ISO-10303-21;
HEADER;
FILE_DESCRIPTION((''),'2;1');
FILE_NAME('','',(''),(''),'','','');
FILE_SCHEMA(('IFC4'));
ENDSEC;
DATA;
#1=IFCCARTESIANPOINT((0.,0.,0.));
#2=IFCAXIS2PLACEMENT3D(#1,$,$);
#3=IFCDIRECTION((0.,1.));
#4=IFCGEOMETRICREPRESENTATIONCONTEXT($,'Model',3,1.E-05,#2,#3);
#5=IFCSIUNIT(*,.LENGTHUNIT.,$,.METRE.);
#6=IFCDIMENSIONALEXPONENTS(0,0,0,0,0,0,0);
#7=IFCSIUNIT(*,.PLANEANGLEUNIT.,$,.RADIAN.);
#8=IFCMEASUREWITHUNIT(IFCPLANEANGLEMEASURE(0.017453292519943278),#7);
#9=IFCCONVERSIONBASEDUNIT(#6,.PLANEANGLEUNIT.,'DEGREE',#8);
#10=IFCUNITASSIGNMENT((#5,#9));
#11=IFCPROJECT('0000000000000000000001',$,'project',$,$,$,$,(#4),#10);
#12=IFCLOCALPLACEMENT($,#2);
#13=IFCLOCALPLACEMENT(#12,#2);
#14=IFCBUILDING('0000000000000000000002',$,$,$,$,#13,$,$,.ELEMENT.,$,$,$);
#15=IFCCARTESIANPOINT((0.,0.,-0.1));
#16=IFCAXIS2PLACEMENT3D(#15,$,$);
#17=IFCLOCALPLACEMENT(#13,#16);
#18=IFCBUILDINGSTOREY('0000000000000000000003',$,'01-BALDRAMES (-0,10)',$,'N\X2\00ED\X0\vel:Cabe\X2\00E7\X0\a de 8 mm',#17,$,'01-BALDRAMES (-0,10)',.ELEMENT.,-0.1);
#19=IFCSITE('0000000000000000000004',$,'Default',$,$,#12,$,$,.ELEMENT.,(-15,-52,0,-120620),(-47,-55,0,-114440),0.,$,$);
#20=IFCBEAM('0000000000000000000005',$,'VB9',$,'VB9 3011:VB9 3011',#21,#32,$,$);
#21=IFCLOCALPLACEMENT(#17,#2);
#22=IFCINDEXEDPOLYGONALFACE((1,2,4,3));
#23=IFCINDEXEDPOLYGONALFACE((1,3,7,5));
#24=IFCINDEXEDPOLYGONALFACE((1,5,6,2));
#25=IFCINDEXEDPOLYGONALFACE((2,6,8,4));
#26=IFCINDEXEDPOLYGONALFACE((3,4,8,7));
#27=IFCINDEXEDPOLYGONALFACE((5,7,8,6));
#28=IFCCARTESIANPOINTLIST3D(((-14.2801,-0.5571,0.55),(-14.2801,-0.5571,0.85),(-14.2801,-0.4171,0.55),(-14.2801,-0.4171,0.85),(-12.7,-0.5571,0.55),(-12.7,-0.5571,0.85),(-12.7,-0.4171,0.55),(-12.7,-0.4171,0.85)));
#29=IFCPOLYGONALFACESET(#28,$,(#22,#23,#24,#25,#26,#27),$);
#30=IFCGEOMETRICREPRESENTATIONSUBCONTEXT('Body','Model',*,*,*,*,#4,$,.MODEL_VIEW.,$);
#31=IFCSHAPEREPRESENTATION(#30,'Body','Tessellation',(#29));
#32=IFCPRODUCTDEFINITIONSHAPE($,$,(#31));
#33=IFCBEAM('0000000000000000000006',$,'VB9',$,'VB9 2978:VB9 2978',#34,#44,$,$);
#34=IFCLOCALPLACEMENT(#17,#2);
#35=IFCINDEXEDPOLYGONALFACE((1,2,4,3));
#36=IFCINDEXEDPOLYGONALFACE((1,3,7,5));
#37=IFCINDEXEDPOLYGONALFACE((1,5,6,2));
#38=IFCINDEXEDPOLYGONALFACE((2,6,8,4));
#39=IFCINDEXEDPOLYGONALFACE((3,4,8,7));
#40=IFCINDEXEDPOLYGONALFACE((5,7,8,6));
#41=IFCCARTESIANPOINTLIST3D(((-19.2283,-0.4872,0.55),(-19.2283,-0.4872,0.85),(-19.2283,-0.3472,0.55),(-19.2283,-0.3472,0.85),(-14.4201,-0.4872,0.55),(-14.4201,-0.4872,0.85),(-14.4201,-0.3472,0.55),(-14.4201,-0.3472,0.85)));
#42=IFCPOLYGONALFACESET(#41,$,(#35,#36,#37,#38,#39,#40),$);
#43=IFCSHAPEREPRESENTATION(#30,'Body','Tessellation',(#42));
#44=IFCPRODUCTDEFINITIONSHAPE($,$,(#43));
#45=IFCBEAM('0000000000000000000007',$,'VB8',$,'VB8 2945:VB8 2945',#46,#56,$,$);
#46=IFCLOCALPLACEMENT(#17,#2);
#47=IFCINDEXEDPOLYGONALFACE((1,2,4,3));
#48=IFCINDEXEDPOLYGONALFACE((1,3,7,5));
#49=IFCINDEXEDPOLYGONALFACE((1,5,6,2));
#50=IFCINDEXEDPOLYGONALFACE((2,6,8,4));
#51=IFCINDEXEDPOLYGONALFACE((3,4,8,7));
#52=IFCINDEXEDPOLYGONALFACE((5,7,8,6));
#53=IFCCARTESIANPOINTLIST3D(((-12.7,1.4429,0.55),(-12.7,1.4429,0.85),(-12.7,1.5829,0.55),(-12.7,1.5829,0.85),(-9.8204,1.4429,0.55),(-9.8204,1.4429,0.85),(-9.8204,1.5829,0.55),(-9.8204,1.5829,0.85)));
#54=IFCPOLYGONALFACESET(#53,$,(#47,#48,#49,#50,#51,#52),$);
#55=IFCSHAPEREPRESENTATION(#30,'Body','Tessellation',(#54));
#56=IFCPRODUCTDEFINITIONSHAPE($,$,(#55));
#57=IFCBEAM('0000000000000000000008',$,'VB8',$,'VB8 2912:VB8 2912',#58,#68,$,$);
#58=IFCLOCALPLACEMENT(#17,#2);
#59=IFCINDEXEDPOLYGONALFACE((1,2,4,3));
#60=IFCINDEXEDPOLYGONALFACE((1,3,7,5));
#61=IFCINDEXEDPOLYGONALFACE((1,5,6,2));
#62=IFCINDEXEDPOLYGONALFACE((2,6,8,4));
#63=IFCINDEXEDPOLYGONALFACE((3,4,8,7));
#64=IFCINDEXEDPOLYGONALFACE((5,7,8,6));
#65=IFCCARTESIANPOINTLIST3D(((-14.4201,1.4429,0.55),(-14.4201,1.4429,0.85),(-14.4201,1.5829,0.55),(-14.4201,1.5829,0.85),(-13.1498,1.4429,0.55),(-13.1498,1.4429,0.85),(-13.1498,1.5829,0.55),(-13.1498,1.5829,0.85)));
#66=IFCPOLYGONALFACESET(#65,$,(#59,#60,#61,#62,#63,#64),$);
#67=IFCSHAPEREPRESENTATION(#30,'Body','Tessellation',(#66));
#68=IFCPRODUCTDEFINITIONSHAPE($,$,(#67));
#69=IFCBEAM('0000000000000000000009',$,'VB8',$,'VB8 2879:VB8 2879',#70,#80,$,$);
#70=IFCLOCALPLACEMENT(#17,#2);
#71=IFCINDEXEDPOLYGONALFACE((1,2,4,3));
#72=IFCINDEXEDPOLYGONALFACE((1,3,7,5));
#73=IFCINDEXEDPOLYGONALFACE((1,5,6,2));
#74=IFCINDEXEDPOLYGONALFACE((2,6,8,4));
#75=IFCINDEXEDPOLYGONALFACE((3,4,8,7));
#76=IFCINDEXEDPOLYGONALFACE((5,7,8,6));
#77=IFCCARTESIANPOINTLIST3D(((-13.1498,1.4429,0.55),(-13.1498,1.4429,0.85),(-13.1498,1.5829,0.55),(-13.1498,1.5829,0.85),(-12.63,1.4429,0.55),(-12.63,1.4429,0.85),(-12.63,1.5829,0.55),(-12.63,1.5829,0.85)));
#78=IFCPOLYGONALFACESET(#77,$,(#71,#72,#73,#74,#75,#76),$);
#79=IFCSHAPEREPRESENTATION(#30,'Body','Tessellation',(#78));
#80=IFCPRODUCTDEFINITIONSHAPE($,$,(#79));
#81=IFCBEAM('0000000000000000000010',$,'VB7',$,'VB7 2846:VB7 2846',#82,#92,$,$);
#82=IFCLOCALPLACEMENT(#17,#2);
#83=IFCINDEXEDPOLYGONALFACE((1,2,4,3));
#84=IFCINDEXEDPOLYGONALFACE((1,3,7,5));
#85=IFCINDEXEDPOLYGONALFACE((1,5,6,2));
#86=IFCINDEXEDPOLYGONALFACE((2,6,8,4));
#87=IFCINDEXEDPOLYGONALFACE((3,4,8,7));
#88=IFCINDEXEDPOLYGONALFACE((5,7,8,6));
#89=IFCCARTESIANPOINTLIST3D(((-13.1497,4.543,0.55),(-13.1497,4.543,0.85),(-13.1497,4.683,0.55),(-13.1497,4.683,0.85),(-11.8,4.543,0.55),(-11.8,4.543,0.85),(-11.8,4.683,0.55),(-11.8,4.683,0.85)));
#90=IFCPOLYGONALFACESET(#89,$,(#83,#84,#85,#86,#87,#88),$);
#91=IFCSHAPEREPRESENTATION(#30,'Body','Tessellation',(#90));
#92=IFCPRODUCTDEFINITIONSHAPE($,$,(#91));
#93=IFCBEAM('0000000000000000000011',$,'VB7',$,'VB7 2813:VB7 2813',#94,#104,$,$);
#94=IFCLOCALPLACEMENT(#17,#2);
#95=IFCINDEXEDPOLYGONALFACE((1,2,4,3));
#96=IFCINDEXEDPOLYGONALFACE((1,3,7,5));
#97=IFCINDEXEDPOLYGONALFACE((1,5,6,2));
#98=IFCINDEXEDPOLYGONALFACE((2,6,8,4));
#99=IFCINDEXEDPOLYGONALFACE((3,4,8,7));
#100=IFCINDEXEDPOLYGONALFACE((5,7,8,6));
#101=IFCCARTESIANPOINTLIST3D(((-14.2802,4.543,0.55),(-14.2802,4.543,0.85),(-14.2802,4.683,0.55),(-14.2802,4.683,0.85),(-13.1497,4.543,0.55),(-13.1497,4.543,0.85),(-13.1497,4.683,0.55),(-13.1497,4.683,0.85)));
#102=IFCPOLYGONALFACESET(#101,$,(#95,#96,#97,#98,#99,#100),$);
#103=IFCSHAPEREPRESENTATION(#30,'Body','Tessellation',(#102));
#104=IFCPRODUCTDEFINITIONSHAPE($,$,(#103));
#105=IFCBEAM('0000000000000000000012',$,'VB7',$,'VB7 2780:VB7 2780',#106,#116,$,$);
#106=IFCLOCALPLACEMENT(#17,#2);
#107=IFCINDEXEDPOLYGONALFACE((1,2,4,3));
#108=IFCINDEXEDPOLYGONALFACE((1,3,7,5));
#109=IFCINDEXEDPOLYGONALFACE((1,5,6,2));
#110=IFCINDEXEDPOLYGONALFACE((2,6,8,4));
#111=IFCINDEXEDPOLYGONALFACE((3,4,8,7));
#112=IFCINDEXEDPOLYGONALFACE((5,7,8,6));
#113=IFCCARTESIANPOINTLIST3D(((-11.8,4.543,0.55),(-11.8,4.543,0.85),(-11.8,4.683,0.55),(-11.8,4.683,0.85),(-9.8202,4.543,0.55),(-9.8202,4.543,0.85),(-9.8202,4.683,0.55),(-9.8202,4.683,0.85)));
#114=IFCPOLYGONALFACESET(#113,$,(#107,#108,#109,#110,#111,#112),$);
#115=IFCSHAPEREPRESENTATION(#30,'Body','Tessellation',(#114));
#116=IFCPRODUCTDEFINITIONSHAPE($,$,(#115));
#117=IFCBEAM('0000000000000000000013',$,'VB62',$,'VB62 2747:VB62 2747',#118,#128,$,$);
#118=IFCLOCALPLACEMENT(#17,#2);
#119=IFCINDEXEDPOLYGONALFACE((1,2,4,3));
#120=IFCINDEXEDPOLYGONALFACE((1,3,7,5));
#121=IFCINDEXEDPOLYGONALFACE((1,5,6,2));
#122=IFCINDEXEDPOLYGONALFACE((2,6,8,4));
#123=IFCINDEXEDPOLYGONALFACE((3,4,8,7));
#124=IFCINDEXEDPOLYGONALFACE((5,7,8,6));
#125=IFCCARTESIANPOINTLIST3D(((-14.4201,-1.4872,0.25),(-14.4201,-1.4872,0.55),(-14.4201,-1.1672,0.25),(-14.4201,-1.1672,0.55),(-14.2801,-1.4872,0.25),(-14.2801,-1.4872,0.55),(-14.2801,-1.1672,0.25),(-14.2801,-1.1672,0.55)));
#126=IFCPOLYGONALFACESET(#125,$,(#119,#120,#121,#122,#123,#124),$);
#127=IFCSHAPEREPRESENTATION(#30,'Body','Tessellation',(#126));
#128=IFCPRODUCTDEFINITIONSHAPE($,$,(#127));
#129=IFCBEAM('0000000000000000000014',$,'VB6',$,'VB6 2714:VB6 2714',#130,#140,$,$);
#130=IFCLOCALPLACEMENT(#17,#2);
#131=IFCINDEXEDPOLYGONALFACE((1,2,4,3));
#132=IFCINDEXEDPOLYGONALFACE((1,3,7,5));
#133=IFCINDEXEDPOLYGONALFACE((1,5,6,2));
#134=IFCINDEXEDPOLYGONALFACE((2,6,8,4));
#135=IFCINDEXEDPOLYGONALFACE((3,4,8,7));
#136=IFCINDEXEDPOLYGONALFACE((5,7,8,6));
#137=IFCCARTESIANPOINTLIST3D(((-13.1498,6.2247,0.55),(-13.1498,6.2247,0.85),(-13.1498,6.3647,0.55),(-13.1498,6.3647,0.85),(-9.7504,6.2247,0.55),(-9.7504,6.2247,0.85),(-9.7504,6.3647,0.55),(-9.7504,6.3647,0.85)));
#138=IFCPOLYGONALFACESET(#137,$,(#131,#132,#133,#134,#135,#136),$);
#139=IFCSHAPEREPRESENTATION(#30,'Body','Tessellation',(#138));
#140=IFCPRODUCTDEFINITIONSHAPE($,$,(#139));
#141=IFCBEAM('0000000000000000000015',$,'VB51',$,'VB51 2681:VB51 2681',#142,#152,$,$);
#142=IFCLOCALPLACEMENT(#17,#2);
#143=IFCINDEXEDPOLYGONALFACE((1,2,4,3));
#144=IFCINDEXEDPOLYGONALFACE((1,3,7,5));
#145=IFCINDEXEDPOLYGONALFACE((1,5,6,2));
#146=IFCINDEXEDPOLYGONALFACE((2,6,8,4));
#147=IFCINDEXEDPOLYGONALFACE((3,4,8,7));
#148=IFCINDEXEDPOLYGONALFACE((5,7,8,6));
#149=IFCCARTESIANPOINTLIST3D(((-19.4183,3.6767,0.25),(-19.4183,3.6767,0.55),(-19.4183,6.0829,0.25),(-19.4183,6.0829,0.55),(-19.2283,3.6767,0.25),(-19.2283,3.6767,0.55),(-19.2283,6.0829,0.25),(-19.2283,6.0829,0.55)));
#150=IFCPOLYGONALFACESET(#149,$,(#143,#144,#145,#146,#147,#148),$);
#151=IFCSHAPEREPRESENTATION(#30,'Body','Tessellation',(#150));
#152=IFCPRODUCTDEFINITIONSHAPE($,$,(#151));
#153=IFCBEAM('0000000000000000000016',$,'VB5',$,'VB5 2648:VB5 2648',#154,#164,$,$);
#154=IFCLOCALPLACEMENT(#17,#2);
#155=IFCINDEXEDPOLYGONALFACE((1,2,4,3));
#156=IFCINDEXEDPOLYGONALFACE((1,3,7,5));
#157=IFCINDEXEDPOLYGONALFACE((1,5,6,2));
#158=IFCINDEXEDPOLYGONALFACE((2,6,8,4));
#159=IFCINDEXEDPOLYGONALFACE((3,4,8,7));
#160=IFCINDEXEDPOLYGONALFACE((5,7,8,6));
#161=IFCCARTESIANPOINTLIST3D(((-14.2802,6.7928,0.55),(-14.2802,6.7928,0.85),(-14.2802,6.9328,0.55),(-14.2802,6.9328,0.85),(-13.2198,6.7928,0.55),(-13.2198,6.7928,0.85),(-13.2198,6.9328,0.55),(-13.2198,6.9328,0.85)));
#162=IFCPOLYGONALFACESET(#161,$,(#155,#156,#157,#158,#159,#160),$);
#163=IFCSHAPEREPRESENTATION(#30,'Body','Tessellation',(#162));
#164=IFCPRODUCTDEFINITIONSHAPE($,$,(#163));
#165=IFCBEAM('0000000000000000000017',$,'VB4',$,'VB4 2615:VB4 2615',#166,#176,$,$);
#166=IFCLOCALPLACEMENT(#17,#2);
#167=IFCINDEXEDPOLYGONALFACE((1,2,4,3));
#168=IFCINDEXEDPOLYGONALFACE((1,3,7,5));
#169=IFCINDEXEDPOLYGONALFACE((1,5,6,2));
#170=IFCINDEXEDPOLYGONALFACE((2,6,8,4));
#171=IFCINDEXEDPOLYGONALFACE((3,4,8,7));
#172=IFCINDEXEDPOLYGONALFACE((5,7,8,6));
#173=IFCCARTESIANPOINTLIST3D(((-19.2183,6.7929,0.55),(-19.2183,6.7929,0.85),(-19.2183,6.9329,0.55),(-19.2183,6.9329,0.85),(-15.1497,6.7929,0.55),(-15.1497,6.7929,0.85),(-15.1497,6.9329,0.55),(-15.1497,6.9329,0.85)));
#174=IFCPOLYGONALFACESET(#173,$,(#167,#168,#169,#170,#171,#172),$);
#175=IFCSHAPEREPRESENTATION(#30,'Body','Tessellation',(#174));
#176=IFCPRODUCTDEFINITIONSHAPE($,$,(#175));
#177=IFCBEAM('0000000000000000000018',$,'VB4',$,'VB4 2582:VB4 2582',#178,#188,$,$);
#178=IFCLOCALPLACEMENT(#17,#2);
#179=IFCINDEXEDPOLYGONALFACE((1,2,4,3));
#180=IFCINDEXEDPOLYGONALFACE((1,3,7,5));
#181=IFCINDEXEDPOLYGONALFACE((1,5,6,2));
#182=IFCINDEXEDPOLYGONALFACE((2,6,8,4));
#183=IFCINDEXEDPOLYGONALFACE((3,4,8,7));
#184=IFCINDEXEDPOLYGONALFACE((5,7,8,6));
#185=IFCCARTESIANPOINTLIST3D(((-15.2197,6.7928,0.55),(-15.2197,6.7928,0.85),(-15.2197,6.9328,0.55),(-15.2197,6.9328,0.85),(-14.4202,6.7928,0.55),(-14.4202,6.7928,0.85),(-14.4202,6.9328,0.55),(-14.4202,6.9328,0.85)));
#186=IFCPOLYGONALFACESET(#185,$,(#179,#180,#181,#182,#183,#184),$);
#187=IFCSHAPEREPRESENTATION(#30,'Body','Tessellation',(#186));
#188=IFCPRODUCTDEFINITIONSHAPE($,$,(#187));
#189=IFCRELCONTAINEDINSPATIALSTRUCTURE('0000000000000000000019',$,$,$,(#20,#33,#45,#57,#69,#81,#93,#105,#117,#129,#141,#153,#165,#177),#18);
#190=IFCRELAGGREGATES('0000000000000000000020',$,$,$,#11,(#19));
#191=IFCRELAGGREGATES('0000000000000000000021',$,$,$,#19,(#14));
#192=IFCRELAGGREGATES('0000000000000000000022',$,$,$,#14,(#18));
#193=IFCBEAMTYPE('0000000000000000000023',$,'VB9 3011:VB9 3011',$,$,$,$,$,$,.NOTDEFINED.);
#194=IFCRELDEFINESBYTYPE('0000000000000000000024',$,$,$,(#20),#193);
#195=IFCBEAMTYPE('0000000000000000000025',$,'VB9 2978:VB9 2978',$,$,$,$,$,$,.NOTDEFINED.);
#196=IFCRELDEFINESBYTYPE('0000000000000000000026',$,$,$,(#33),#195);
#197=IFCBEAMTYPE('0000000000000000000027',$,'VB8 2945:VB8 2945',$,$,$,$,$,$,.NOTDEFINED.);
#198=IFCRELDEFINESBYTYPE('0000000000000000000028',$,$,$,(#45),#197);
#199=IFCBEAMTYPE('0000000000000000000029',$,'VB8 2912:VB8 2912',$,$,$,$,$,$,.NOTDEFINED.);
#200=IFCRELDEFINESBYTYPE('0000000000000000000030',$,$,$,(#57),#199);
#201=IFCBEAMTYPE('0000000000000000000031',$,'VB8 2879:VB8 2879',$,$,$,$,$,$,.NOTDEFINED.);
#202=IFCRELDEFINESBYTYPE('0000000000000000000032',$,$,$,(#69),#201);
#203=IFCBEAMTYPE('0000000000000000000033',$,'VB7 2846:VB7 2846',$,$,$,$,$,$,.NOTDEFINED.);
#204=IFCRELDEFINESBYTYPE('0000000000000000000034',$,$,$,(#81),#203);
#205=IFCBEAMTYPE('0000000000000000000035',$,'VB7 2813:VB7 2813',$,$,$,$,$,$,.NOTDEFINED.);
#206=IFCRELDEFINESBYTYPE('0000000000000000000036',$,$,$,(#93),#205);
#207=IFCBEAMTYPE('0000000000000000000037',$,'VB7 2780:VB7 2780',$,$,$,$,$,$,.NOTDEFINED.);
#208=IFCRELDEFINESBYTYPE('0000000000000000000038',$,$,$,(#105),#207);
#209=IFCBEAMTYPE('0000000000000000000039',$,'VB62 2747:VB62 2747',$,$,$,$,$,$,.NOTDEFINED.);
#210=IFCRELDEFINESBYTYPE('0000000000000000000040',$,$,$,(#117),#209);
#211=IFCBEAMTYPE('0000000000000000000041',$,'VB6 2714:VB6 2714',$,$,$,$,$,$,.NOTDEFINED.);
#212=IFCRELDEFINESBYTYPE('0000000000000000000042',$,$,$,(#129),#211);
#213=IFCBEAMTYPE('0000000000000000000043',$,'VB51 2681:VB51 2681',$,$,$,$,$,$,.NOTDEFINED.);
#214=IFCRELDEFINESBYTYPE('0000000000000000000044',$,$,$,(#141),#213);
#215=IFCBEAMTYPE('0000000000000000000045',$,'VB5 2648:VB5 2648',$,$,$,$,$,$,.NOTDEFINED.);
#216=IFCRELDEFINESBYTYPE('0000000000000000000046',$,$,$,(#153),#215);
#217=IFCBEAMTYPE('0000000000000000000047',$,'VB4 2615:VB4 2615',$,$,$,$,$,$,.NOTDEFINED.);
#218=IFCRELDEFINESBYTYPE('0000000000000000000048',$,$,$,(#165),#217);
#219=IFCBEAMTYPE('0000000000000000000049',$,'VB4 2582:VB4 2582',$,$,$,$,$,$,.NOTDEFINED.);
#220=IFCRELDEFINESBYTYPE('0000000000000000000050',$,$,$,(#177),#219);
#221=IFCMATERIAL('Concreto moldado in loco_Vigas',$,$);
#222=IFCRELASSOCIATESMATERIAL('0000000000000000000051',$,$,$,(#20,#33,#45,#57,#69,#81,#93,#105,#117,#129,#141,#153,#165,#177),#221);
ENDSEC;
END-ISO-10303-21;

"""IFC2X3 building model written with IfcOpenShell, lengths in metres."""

from ifc_helpers import new_model, entity, si_unit, converted_unit, direction, frame, frame_2d, origin, origin_2d_with_axis, place, context, subcontext, project, spatial, rectangle, extrude, material, type_object, element, save


model = new_model("IFC2X3")

# Units and contexts
model_context = context("Model", 3, precision=1e-05, world=origin(), true_north=direction((0.0, 1.0)))
body_context = subcontext(model_context, "Body", "Model", "MODEL_VIEW")
ifc_project = project(units=[si_unit("LENGTHUNIT", "METRE"), converted_unit("PLANEANGLEUNIT", "DEGREE", entity("IfcPlaneAngleMeasure", 0.017453292519943278), si_unit("PLANEANGLEUNIT", "RADIAN"), dimensions=[0, 0, 0, 0, 0, 0, 0])], contexts=[model_context])

# Site, building, storey
site_placement = place(None, origin())
site = spatial("IfcSite", under=ifc_project, at=site_placement, Name="Default", CompositionType="ELEMENT", RefLatitude=(-15, -52, 0, -120620), RefLongitude=(-47, -55, 0, -114440), RefElevation=0.0)
building_placement = place(site_placement, origin())
building = spatial("IfcBuilding", under=site, at=building_placement, CompositionType="ELEMENT")
storey_placement = place(building_placement, frame((0.0, 0.0, -0.1)))
storey = spatial("IfcBuildingStorey", under=building, at=storey_placement, Name="01-BALDRAMES (-0,10)", ObjectType="Nível:Cabeça de 8 mm", LongName="01-BALDRAMES (-0,10)", CompositionType="ELEMENT", Elevation=-0.1)

# Beams
ifc_material_1 = material(Name="Concreto moldado in loco_Vigas")
beam_type_1 = type_object("IfcBeamType", Name="VB9 3011:VB9 3011", PredefinedType="NOTDEFINED")
beam_1_placement = place(storey_placement, origin())
element("IfcBeam", 1, at=beam_1_placement, inside=storey, type_object=beam_type_1, material=ifc_material_1, Name="VB9", ObjectType="VB9 3011:VB9 3011", context=body_context, shape_type="SweptSolid", body=[
    extrude(rectangle(XDim=0.3, YDim=0.14, at=origin_2d_with_axis()), frame((-14.2801, -0.4871, 0.7), z_axis=(1.0, 0.0, 0.0), x_axis=(0.0, 0.0, -1.0)), (0.0, 0.0, 1.0), 1.5801),
])
beam_type_2 = type_object("IfcBeamType", Name="VB9 2978:VB9 2978", PredefinedType="NOTDEFINED")
beam_2_placement = place(storey_placement, origin())
element("IfcBeam", 2, at=beam_2_placement, inside=storey, type_object=beam_type_2, material=ifc_material_1, Name="VB9", ObjectType="VB9 2978:VB9 2978", context=body_context, shape_type="SweptSolid", body=[
    extrude(rectangle(XDim=0.3, YDim=0.14, at=origin_2d_with_axis()), frame((-19.2283, -0.4172, 0.7), z_axis=(1.0, 0.0, 0.0), x_axis=(0.0, 0.0, -1.0)), (0.0, 0.0, 1.0), 4.8082),
])
beam_type_3 = type_object("IfcBeamType", Name="VB8 2945:VB8 2945", PredefinedType="NOTDEFINED")
beam_3_placement = place(storey_placement, origin())
element("IfcBeam", 3, at=beam_3_placement, inside=storey, type_object=beam_type_3, material=ifc_material_1, Name="VB8", ObjectType="VB8 2945:VB8 2945", context=body_context, shape_type="SweptSolid", body=[
    extrude(rectangle(XDim=0.3, YDim=0.14, at=origin_2d_with_axis()), frame((-12.7, 1.5129, 0.7), z_axis=(1.0, 0.0, 0.0), x_axis=(0.0, 0.0, -1.0)), (0.0, 0.0, 1.0), 2.8796),
])
beam_type_4 = type_object("IfcBeamType", Name="VB8 2912:VB8 2912", PredefinedType="NOTDEFINED")
beam_4_placement = place(storey_placement, origin())
element("IfcBeam", 4, at=beam_4_placement, inside=storey, type_object=beam_type_4, material=ifc_material_1, Name="VB8", ObjectType="VB8 2912:VB8 2912", context=body_context, shape_type="SweptSolid", body=[
    extrude(rectangle(XDim=0.3, YDim=0.14, at=origin_2d_with_axis()), frame((-14.4201, 1.5129, 0.7), z_axis=(1.0, 0.0, 0.0), x_axis=(0.0, 0.0, -1.0)), (0.0, 0.0, 1.0), 1.2703),
])
beam_type_5 = type_object("IfcBeamType", Name="VB8 2879:VB8 2879", PredefinedType="NOTDEFINED")
beam_5_placement = place(storey_placement, origin())
element("IfcBeam", 5, at=beam_5_placement, inside=storey, type_object=beam_type_5, material=ifc_material_1, Name="VB8", ObjectType="VB8 2879:VB8 2879", context=body_context, shape_type="SweptSolid", body=[
    extrude(rectangle(XDim=0.3, YDim=0.14, at=origin_2d_with_axis()), frame((-13.1498, 1.5129, 0.7), z_axis=(1.0, 0.0, 0.0), x_axis=(0.0, 0.0, -1.0)), (0.0, 0.0, 1.0), 0.5198),
])
beam_type_6 = type_object("IfcBeamType", Name="VB7 2846:VB7 2846", PredefinedType="NOTDEFINED")
beam_6_placement = place(storey_placement, origin())
element("IfcBeam", 6, at=beam_6_placement, inside=storey, type_object=beam_type_6, material=ifc_material_1, Name="VB7", ObjectType="VB7 2846:VB7 2846", context=body_context, shape_type="SweptSolid", body=[
    extrude(rectangle(XDim=0.3, YDim=0.14, at=frame_2d((0.0, 0.0), x_axis=(1.0, 0.0))), frame((-13.1497, 4.613, 0.7), z_axis=(1.0, 0.0, 0.0), x_axis=(0.0, 0.0, -1.0)), (0.0, 0.0, 1.0), 1.3497),
])
beam_type_7 = type_object("IfcBeamType", Name="VB7 2813:VB7 2813", PredefinedType="NOTDEFINED")
beam_7_placement = place(storey_placement, origin())
element("IfcBeam", 7, at=beam_7_placement, inside=storey, type_object=beam_type_7, material=ifc_material_1, Name="VB7", ObjectType="VB7 2813:VB7 2813", context=body_context, shape_type="SweptSolid", body=[
    extrude(rectangle(XDim=0.3, YDim=0.14, at=frame_2d((0.0, 0.0), x_axis=(1.0, 0.0))), frame((-14.2802, 4.613, 0.7), z_axis=(1.0, 0.0, 0.0), x_axis=(0.0, 0.0, -1.0)), (0.0, 0.0, 1.0), 1.1305),
])
beam_type_8 = type_object("IfcBeamType", Name="VB7 2780:VB7 2780", PredefinedType="NOTDEFINED")
beam_8_placement = place(storey_placement, origin())
element("IfcBeam", 8, at=beam_8_placement, inside=storey, type_object=beam_type_8, material=ifc_material_1, Name="VB7", ObjectType="VB7 2780:VB7 2780", context=body_context, shape_type="SweptSolid", body=[
    extrude(rectangle(XDim=0.3, YDim=0.14, at=frame_2d((0.0, 0.0), x_axis=(1.0, 0.0))), frame((-11.8, 4.613, 0.7), z_axis=(1.0, 0.0, 0.0), x_axis=(0.0, 0.0, -1.0)), (0.0, 0.0, 1.0), 1.9798),
])
beam_type_9 = type_object("IfcBeamType", Name="VB62 2747:VB62 2747", PredefinedType="NOTDEFINED")
beam_9_placement = place(storey_placement, origin())
element("IfcBeam", 9, at=beam_9_placement, inside=storey, type_object=beam_type_9, material=ifc_material_1, Name="VB62", ObjectType="VB62 2747:VB62 2747", context=body_context, shape_type="SweptSolid", body=[
    extrude(rectangle(XDim=0.3, YDim=0.32, at=frame_2d((0.0, 0.0), x_axis=(0.0, 1.0))), frame((-14.4201, -1.3272, 0.4), z_axis=(1.0, 0.0, 0.0), x_axis=(0.0, -1.0, 0.0)), (0.0, 0.0, 1.0), 0.14),
])
beam_type_10 = type_object("IfcBeamType", Name="VB6 2714:VB6 2714", PredefinedType="NOTDEFINED")
beam_10_placement = place(storey_placement, origin())
element("IfcBeam", 10, at=beam_10_placement, inside=storey, type_object=beam_type_10, material=ifc_material_1, Name="VB6", ObjectType="VB6 2714:VB6 2714", context=body_context, shape_type="SweptSolid", body=[
    extrude(rectangle(XDim=0.3, YDim=0.14, at=frame_2d((0.0, 0.0), x_axis=(1.0, 0.0))), frame((-13.1498, 6.2947, 0.7), z_axis=(1.0, 0.0, 0.0), x_axis=(0.0, 0.0, -1.0)), (0.0, 0.0, 1.0), 3.3994),
])
beam_type_11 = type_object("IfcBeamType", Name="VB51 2681:VB51 2681", PredefinedType="NOTDEFINED")
beam_11_placement = place(storey_placement, origin())
element("IfcBeam", 11, at=beam_11_placement, inside=storey, type_object=beam_type_11, material=ifc_material_1, Name="VB51", ObjectType="VB51 2681:VB51 2681", context=body_context, shape_type="SweptSolid", body=[
    extrude(rectangle(XDim=0.3, YDim=2.4062, at=frame_2d((0.0, 0.0), x_axis=(0.0, 1.0))), frame((-19.4183, 4.8798, 0.4), z_axis=(1.0, 0.0, 0.0), x_axis=(0.0, -1.0, 0.0)), (0.0, 0.0, 1.0), 0.19),
])
beam_type_12 = type_object("IfcBeamType", Name="VB5 2648:VB5 2648", PredefinedType="NOTDEFINED")
beam_12_placement = place(storey_placement, origin())
element("IfcBeam", 12, at=beam_12_placement, inside=storey, type_object=beam_type_12, material=ifc_material_1, Name="VB5", ObjectType="VB5 2648:VB5 2648", context=body_context, shape_type="SweptSolid", body=[
    extrude(rectangle(XDim=0.3, YDim=0.14, at=frame_2d((0.0, 0.0), x_axis=(1.0, 0.0))), frame((-14.2802, 6.8628, 0.7), z_axis=(1.0, 0.0, 0.0), x_axis=(0.0, 0.0, -1.0)), (0.0, 0.0, 1.0), 1.0604),
])
beam_type_13 = type_object("IfcBeamType", Name="VB4 2615:VB4 2615", PredefinedType="NOTDEFINED")
beam_13_placement = place(storey_placement, origin())
element("IfcBeam", 13, at=beam_13_placement, inside=storey, type_object=beam_type_13, material=ifc_material_1, Name="VB4", ObjectType="VB4 2615:VB4 2615", context=body_context, shape_type="SweptSolid", body=[
    extrude(rectangle(XDim=0.3, YDim=0.14, at=frame_2d((0.0, 0.0), x_axis=(1.0, 0.0))), frame((-19.2183, 6.8629, 0.7), z_axis=(1.0, 0.0, 0.0), x_axis=(0.0, 0.0, -1.0)), (0.0, 0.0, 1.0), 4.0686),
])
beam_type_14 = type_object("IfcBeamType", Name="VB4 2582:VB4 2582", PredefinedType="NOTDEFINED")
beam_14_placement = place(storey_placement, origin())
element("IfcBeam", 14, at=beam_14_placement, inside=storey, type_object=beam_type_14, material=ifc_material_1, Name="VB4", ObjectType="VB4 2582:VB4 2582", context=body_context, shape_type="SweptSolid", body=[
    extrude(rectangle(XDim=0.3, YDim=0.14, at=frame_2d((0.0, 0.0), x_axis=(1.0, 0.0))), frame((-15.2197, 6.8628, 0.7), z_axis=(1.0, 0.0, 0.0), x_axis=(0.0, 0.0, -1.0)), (0.0, 0.0, 1.0), 0.7995),
])

save(model, "model.ifc")
